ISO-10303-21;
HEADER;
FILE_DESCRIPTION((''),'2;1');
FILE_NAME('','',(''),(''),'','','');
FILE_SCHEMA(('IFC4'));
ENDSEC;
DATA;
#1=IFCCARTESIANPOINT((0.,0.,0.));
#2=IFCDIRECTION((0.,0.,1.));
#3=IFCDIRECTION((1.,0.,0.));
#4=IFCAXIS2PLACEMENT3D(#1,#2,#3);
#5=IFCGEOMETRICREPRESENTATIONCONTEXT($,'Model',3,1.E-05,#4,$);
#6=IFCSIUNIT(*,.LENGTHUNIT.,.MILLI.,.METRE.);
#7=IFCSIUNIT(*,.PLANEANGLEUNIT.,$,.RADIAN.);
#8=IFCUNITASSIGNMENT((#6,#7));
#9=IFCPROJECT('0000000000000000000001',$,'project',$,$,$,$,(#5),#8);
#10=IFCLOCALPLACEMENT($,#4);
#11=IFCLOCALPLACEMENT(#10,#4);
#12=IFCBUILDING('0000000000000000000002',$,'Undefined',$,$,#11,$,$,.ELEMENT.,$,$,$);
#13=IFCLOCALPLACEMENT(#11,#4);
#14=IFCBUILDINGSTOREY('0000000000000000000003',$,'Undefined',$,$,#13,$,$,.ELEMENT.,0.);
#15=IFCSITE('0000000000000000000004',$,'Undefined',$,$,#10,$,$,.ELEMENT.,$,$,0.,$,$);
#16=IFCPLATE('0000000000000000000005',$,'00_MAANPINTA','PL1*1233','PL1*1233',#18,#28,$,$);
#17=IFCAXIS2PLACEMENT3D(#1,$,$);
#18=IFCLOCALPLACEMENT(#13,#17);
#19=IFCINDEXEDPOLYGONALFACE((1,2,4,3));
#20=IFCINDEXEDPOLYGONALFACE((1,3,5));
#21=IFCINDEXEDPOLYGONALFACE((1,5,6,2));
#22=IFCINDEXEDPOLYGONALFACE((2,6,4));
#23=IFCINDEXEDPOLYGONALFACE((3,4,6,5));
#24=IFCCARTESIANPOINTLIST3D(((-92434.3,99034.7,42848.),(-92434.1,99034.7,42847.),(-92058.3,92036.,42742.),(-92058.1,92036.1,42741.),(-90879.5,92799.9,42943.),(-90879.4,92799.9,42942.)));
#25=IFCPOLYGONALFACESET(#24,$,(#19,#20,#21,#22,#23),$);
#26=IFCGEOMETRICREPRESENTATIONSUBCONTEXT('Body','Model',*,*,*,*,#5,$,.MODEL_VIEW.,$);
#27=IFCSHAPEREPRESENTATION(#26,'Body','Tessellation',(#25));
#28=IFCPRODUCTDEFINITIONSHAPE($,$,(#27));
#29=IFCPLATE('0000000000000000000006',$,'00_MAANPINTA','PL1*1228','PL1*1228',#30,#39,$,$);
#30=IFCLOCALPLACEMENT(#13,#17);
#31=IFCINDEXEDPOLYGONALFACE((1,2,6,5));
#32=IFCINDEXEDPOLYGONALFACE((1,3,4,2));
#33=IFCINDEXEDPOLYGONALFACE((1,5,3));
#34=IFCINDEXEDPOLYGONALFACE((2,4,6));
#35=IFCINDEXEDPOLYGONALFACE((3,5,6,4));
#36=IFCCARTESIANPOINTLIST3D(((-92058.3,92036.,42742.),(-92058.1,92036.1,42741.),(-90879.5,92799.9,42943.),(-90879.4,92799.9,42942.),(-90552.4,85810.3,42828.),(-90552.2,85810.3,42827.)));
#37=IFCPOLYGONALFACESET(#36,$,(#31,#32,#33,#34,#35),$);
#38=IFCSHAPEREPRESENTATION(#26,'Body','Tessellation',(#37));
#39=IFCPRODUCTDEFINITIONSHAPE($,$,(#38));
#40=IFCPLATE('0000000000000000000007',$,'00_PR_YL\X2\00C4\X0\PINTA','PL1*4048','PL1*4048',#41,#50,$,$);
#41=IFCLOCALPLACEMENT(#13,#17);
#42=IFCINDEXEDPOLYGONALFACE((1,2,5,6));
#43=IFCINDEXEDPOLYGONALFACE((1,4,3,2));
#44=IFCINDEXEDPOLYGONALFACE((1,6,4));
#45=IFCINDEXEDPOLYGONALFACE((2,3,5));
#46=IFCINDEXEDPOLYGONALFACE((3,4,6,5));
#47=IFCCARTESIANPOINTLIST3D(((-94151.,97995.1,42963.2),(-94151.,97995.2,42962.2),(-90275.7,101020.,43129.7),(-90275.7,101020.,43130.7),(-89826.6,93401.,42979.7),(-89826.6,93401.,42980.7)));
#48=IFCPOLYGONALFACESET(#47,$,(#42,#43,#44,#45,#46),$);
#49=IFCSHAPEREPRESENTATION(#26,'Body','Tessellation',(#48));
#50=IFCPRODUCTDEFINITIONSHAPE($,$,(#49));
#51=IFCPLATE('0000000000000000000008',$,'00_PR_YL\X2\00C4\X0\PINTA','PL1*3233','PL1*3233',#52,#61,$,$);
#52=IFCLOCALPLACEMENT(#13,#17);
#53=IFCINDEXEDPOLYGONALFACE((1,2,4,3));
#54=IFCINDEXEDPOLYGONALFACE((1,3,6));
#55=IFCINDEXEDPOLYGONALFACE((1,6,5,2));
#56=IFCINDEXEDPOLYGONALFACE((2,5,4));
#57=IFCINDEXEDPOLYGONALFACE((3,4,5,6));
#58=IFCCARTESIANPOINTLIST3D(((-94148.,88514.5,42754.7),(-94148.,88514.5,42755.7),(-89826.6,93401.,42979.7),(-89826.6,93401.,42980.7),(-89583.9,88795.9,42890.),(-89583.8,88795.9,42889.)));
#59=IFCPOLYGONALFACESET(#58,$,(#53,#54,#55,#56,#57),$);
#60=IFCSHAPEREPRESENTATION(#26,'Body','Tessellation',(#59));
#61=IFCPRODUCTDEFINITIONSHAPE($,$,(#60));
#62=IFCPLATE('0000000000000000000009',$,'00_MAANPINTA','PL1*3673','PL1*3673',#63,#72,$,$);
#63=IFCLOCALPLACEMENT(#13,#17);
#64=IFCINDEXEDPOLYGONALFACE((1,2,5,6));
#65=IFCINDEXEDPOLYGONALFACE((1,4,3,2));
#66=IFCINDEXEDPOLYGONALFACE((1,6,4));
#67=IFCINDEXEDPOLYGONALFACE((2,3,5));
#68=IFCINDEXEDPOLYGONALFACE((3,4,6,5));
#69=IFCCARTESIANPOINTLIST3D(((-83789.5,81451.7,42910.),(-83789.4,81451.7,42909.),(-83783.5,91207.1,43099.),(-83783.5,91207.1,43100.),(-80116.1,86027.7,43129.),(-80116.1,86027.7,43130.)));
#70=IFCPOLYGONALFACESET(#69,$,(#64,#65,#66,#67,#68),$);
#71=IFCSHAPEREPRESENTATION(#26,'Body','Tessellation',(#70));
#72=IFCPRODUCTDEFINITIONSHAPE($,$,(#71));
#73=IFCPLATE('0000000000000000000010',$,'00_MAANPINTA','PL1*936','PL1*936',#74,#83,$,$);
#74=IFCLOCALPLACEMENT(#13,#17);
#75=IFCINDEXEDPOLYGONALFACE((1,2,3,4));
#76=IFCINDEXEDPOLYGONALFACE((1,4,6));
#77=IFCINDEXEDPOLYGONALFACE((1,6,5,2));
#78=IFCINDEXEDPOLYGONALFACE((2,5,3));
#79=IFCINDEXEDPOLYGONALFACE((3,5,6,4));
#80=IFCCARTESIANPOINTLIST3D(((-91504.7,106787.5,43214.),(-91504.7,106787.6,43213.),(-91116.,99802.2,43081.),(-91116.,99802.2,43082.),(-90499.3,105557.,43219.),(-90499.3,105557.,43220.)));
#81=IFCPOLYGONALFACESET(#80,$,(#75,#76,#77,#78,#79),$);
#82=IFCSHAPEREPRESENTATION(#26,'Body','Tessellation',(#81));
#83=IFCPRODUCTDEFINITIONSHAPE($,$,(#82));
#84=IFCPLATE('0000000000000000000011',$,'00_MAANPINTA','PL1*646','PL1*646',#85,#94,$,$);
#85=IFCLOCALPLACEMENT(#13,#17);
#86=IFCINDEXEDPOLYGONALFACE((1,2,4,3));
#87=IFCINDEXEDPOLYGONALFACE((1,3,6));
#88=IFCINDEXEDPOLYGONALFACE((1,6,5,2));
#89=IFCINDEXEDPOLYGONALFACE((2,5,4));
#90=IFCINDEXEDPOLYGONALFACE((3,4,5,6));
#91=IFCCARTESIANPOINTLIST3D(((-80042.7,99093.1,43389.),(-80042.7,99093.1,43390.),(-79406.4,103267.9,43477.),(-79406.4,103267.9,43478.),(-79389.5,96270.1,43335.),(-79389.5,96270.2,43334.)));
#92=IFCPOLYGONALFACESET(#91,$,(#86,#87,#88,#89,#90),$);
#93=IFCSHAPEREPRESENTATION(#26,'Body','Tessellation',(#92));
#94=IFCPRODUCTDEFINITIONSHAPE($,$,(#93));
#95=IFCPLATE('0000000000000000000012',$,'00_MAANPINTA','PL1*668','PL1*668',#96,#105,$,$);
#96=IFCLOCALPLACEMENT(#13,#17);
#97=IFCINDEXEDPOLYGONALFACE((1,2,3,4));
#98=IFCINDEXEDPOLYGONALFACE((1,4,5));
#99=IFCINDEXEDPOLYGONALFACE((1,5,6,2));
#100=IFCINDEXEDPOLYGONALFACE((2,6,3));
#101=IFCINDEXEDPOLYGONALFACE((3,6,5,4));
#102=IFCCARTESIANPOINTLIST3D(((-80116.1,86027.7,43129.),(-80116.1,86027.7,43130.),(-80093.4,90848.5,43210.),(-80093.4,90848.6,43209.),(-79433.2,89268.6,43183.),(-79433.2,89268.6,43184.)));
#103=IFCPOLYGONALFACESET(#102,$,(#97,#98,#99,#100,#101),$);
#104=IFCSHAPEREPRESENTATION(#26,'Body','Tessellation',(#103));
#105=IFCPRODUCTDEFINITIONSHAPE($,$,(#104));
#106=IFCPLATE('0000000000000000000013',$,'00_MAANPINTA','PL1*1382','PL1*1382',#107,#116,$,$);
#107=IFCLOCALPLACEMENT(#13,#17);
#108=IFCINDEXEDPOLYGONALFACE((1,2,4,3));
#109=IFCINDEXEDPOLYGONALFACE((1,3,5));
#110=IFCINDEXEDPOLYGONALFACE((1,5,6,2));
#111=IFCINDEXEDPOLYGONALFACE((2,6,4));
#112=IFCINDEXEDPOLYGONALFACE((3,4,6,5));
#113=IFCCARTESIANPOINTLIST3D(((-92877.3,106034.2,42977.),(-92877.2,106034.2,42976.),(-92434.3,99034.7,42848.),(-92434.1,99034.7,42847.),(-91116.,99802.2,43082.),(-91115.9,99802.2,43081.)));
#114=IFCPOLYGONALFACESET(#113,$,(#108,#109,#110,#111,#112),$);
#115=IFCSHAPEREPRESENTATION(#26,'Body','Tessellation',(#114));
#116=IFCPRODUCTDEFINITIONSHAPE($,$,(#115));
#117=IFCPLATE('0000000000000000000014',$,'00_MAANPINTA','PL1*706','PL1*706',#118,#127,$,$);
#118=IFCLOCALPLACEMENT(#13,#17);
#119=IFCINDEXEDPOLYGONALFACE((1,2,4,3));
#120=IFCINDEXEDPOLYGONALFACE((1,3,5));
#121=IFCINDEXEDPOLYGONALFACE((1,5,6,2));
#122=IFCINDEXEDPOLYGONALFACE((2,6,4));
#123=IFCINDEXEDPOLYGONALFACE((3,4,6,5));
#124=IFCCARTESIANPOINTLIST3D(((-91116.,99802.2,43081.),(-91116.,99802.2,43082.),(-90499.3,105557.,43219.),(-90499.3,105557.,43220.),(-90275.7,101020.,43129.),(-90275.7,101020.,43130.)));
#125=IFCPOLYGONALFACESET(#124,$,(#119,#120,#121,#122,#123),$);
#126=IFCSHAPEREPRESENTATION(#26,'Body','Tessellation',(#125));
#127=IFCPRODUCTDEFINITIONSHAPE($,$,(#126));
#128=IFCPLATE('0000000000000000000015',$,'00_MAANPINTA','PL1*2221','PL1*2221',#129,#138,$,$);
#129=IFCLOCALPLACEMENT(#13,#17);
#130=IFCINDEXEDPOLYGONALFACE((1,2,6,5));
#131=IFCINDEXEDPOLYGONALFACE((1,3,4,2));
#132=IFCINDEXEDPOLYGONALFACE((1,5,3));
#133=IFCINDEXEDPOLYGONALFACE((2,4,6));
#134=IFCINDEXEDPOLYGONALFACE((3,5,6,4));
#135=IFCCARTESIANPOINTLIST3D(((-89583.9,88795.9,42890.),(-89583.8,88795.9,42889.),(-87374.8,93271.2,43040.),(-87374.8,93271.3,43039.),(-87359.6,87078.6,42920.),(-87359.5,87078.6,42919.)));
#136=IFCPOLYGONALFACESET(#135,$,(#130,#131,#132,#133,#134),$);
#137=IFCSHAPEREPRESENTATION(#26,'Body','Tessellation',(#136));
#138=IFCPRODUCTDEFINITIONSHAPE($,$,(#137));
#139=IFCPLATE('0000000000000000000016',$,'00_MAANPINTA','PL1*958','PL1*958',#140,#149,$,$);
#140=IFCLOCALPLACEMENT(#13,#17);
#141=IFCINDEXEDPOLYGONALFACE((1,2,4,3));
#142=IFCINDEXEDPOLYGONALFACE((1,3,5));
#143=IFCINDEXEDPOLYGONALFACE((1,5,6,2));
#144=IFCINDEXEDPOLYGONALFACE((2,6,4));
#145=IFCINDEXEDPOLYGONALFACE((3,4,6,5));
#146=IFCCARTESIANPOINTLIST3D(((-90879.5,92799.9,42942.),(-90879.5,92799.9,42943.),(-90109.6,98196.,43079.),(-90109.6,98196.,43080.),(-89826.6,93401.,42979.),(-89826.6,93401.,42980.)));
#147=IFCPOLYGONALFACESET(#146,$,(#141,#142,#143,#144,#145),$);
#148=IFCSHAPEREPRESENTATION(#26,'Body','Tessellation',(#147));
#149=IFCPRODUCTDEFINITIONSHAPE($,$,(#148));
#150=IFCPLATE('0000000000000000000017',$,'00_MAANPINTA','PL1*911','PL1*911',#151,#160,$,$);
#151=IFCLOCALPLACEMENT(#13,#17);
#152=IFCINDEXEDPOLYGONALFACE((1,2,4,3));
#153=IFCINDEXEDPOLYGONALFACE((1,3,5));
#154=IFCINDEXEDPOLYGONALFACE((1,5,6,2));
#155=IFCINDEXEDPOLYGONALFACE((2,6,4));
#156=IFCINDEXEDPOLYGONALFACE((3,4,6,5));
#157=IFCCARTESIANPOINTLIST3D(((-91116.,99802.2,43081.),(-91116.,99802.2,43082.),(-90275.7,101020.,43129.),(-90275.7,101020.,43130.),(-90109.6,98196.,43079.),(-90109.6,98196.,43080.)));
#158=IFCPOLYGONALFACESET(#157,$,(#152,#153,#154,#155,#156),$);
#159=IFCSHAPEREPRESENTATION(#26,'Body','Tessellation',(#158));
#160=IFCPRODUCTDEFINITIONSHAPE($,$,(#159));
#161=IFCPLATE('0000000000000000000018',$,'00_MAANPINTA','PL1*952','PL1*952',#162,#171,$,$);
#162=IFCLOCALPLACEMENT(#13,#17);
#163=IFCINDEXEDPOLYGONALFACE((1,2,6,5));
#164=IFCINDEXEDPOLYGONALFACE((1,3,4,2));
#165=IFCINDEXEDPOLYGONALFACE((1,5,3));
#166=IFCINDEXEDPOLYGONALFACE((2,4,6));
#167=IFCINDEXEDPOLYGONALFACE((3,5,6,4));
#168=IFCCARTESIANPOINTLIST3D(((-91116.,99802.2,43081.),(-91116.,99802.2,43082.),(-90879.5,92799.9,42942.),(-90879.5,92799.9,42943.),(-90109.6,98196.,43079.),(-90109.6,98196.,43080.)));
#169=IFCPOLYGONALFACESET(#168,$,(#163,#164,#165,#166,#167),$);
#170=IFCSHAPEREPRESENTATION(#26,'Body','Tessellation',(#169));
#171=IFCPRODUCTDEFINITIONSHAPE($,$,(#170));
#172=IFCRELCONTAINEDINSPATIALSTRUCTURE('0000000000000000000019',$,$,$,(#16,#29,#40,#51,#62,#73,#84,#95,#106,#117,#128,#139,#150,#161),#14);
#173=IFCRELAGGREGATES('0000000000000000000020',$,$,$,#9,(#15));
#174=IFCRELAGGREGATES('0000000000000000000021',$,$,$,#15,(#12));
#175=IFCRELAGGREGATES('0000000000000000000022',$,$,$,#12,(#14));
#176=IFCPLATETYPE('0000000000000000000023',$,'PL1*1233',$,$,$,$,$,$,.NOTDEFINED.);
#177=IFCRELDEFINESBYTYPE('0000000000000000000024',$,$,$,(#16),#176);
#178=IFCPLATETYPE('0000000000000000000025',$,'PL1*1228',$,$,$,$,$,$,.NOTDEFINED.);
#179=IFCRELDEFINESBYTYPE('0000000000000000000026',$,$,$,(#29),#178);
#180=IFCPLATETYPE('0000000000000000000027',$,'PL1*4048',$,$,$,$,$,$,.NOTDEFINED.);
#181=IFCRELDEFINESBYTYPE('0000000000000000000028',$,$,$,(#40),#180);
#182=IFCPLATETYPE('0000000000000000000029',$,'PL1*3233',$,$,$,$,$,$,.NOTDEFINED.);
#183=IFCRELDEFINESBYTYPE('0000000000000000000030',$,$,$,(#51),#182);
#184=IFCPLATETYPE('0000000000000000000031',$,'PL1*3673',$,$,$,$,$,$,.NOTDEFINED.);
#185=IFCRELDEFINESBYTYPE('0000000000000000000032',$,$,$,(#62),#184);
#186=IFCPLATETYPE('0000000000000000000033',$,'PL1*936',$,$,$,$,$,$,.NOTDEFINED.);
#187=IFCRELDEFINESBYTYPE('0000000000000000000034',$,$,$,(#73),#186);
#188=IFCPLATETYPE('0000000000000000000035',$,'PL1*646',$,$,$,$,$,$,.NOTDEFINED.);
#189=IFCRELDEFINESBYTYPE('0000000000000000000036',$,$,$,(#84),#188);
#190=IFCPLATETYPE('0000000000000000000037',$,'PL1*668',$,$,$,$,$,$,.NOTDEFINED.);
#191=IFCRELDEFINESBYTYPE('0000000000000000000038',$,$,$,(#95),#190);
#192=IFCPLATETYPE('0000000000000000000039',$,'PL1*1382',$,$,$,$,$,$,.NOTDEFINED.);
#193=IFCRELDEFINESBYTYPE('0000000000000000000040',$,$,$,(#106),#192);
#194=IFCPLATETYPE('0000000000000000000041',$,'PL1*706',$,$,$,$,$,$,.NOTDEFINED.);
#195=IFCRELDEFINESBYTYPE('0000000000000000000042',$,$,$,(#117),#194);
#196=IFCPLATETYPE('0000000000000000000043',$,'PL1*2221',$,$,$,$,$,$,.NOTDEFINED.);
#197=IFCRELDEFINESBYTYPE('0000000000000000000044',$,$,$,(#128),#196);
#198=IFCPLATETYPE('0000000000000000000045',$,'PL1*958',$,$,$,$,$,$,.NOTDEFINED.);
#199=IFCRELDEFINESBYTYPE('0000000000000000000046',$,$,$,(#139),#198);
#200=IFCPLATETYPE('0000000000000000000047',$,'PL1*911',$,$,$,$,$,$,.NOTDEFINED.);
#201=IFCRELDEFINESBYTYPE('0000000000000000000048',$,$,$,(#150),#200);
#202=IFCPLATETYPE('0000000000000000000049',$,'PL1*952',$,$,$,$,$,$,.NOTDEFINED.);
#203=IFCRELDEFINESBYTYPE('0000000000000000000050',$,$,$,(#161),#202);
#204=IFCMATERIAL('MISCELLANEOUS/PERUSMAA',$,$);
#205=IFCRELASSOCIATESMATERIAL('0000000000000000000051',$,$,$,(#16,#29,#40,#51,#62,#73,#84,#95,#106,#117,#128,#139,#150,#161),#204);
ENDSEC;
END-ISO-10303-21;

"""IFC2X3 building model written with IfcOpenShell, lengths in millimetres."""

from ifc_helpers import new_model, si_unit, frame, origin_with_axes, place, context, subcontext, project, spatial, polyline, outline, extrude, material, type_object, element, save


model = new_model("IFC2X3")

# Units and contexts
model_context = context("Model", 3, precision=1e-05, world=origin_with_axes())
body_context = subcontext(model_context, "Body", "Model", "MODEL_VIEW")
ifc_project = project(units=[si_unit("LENGTHUNIT", "METRE", prefix="MILLI"), si_unit("PLANEANGLEUNIT", "RADIAN")], contexts=[model_context])

# Site, building, storey
site_placement = place(None, origin_with_axes())
site = spatial("IfcSite", under=ifc_project, at=site_placement, Name="Undefined", CompositionType="ELEMENT", RefElevation=0.0)
building_placement = place(site_placement, origin_with_axes())
building = spatial("IfcBuilding", under=site, at=building_placement, Name="Undefined", CompositionType="ELEMENT")
storey_placement = place(building_placement, origin_with_axes())
storey = spatial("IfcBuildingStorey", under=building, at=storey_placement, Name="Undefined", CompositionType="ELEMENT", Elevation=0.0)

# Plates
ifc_material = material(Name="MISCELLANEOUS/PERUSMAA")
plate_type_1 = type_object("IfcPlateType", Name="PL1*1233", PredefinedType="NOTDEFINED")
plate_1_placement = place(storey_placement, frame((-90879.4, 92799.9, 42942.5), z_axis=(0.153412, 0.023203, -0.98789), x_axis=(-0.830745, -0.538328, -0.141653)))
element("IfcPlate", 1, at=plate_1_placement, inside=storey, type_object=plate_type_1, material=ifc_material, Name="00_MAANPINTA", Description="PL1*1233", ObjectType="PL1*1233", context=body_context, shape_type="SweptSolid", body=[
    extrude(outline(polyline([(0.0, 0.0), (1419.0, 0.0), (-2051.3, 6090.2), (0.0, 0.0)])), frame((0.0, 0.0, -0.5), z_axis=(0.0, 0.0, 1.0), x_axis=(1.0, 0.0, 0.0)), (0.0, 0.0, 1.0), 1.0),
])
plate_type_2 = type_object("IfcPlateType", Name="PL1*1228", PredefinedType="NOTDEFINED")
plate_2_placement = place(storey_placement, frame((-90879.4, 92799.9, 42942.5), z_axis=(0.15327, 0.023427, -0.987907), x_axis=(0.046745, -0.998772, -0.016433)))
element("IfcPlate", 2, at=plate_2_placement, inside=storey, type_object=plate_type_2, material=ifc_material, Name="00_MAANPINTA", Description="PL1*1228", ObjectType="PL1*1228", context=body_context, shape_type="SweptSolid", body=[
    extrude(outline(polyline([(0.0, 0.0), (6998.2, 0.0), (711.1, 1227.9), (0.0, 0.0)])), frame((0.0, 0.0, -0.5), z_axis=(0.0, 0.0, 1.0), x_axis=(1.0, 0.0, 0.0)), (0.0, 0.0, 1.0), 1.0),
])
plate_type_3 = type_object("IfcPlateType", Name="PL1*4048", PredefinedType="NOTDEFINED")
plate_3_placement = place(storey_placement, frame((-90275.7, 101020.0, 43130.2), z_axis=(0.02661, 0.02125, -0.99942), x_axis=(0.058825, -0.998075, -0.019655)))
element("IfcPlate", 3, at=plate_3_placement, inside=storey, type_object=plate_type_3, material=ifc_material, Name="00_PR_YLÄPINTA", Description="PL1*4048", ObjectType="PL1*4048", context=body_context, shape_type="SweptSolid", body=[
    extrude(outline(polyline([(0.0, 0.0), (7633.7, 0.0), (2794.4, 4048.2), (0.0, 0.0)])), frame((0.0, 0.0, -0.5), z_axis=(0.0, 0.0, 1.0), x_axis=(1.0, 0.0, 0.0)), (0.0, 0.0, 1.0), 1.0),
])
plate_type_4 = type_object("IfcPlateType", Name="PL1*3233", PredefinedType="NOTDEFINED")
plate_4_placement = place(storey_placement, frame((-89826.6, 93401.0, 42980.2), z_axis=(0.02811, 0.021156, -0.999381), x_axis=(0.052634, -0.99842, -0.019655)))
element("IfcPlate", 4, at=plate_4_placement, inside=storey, type_object=plate_type_4, material=ifc_material, Name="00_PR_YLÄPINTA", Description="PL1*3233", ObjectType="PL1*3233", context=body_context, shape_type="SweptSolid", body=[
    extrude(outline(polyline([(0.0, 0.0), (4612.4, 0.0), (4655.7, 4574.6), (0.0, 0.0)])), frame((0.0, 0.0, -0.5), z_axis=(0.0, 0.0, 1.0), x_axis=(1.0, 0.0, 0.0)), (0.0, 0.0, 1.0), 1.0),
])
plate_type_5 = type_object("IfcPlateType", Name="PL1*3673", PredefinedType="NOTDEFINED")
plate_5_placement = place(storey_placement, frame((-83783.5, 91207.1, 43099.5), z_axis=(0.035626, 0.019438, -0.999176), x_axis=(0.577874, -0.816113, 0.004727)))
element("IfcPlate", 5, at=plate_5_placement, inside=storey, type_object=plate_type_5, material=ifc_material, Name="00_MAANPINTA", Description="PL1*3673", ObjectType="PL1*3673", context=body_context, shape_type="SweptSolid", body=[
    extrude(outline(polyline([(0.0, 0.0), (6346.4, 0.0), (7957.2, 5646.9), (0.0, 0.0)])), frame((0.0, 0.0, -0.5), z_axis=(0.0, 0.0, 1.0), x_axis=(1.0, 0.0, 0.0)), (0.0, 0.0, 1.0), 1.0),
])
plate_type_6 = type_object("IfcPlateType", Name="PL1*936", PredefinedType="NOTDEFINED")
plate_6_placement = place(storey_placement, frame((-91116.0, 99802.2, 43081.5), z_axis=(0.0312, 0.020619, -0.9993), x_axis=(-0.055545, 0.998278, 0.018864)))
element("IfcPlate", 6, at=plate_6_placement, inside=storey, type_object=plate_type_6, material=ifc_material, Name="00_MAANPINTA", Description="PL1*936", ObjectType="PL1*936", context=body_context, shape_type="SweptSolid", body=[
    extrude(outline(polyline([(0.0, 0.0), (6997.4, 0.0), (5713.2, 936.0), (0.0, 0.0)])), frame((0.0, 0.0, -0.5), z_axis=(0.0, 0.0, 1.0), x_axis=(1.0, 0.0, 0.0)), (0.0, 0.0, 1.0), 1.0),
])
plate_type_7 = type_object("IfcPlateType", Name="PL1*646", PredefinedType="NOTDEFINED")
plate_7_placement = place(storey_placement, frame((-80042.7, 99093.1, 43389.5), z_axis=(0.004157, 0.020441, -0.999782), x_axis=(0.15064, 0.988369, 0.020834)))
element("IfcPlate", 7, at=plate_7_placement, inside=storey, type_object=plate_type_7, material=ifc_material, Name="00_MAANPINTA", Description="PL1*646", ObjectType="PL1*646", context=body_context, shape_type="SweptSolid", body=[
    extrude(outline(polyline([(0.0, 0.0), (4223.9, 0.0), (-2692.8, 1071.1), (0.0, 0.0)])), frame((0.0, 0.0, -0.5), z_axis=(0.0, 0.0, 1.0), x_axis=(1.0, 0.0, 0.0)), (0.0, 0.0, 1.0), 1.0),
])
plate_type_8 = type_object("IfcPlateType", Name="PL1*668", PredefinedType="NOTDEFINED")
plate_8_placement = place(storey_placement, frame((-80093.4, 90848.6, 43209.5), z_axis=(0.000328, 0.016591, -0.999862), x_axis=(0.38552, -0.922574, -0.015182)))
element("IfcPlate", 8, at=plate_8_placement, inside=storey, type_object=plate_type_8, material=ifc_material, Name="00_MAANPINTA", Description="PL1*668", ObjectType="PL1*668", context=body_context, shape_type="SweptSolid", body=[
    extrude(outline(polyline([(0.0, 0.0), (1712.6, 0.0), (4440.0, 1879.7), (0.0, 0.0)])), frame((0.0, 0.0, -0.5), z_axis=(0.0, 0.0, 1.0), x_axis=(1.0, 0.0, 0.0)), (0.0, 0.0, 1.0), 1.0),
])
plate_type_9 = type_object("IfcPlateType", Name="PL1*1382", PredefinedType="NOTDEFINED")
plate_9_placement = place(storey_placement, frame((-91116.0, 99802.2, 43081.5), z_axis=(0.158749, 0.028237, -0.986915), x_axis=(-0.854187, -0.497367, -0.15163)))
element("IfcPlate", 9, at=plate_9_placement, inside=storey, type_object=plate_type_9, material=ifc_material, Name="00_MAANPINTA", Description="PL1*1382", ObjectType="PL1*1382", context=body_context, shape_type="SweptSolid", body=[
    extrude(outline(polyline([(0.0, 0.0), (1543.2, 0.0), (-1579.2, 6281.5), (0.0, 0.0)])), frame((0.0, 0.0, -0.5), z_axis=(0.0, 0.0, 1.0), x_axis=(1.0, 0.0, 0.0)), (0.0, 0.0, 1.0), 1.0),
])
plate_type_10 = type_object("IfcPlateType", Name="PL1*706", PredefinedType="NOTDEFINED")
plate_10_placement = place(storey_placement, frame((-91116.0, 99802.2, 43081.5), z_axis=(0.026466, 0.02113, -0.999426), x_axis=(0.106531, 0.994024, 0.023837)))
element("IfcPlate", 10, at=plate_10_placement, inside=storey, type_object=plate_type_10, material=ifc_material, Name="00_MAANPINTA", Description="PL1*706", ObjectType="PL1*706", context=body_context, shape_type="SweptSolid", body=[
    extrude(outline(polyline([(0.0, 0.0), (5789.4, 0.0), (1301.2, 706.0), (0.0, 0.0)])), frame((0.0, 0.0, -0.5), z_axis=(0.0, 0.0, 1.0), x_axis=(1.0, 0.0, 0.0)), (0.0, 0.0, 1.0), 1.0),
])
plate_type_11 = type_object("IfcPlateType", Name="PL1*2221", PredefinedType="NOTDEFINED")
plate_11_placement = place(storey_placement, frame((-87374.8, 93271.3, 43039.5), z_axis=(0.028485, 0.019436, -0.999405), x_axis=(0.002463, -0.999809, -0.019374)))
element("IfcPlate", 11, at=plate_11_placement, inside=storey, type_object=plate_type_11, material=ifc_material, Name="00_MAANPINTA", Description="PL1*2221", ObjectType="PL1*2221", context=body_context, shape_type="SweptSolid", body=[
    extrude(outline(polyline([(0.0, 0.0), (6193.8, 0.0), (4472.0, 2221.0), (0.0, 0.0)])), frame((0.0, 0.0, -0.5), z_axis=(0.0, 0.0, 1.0), x_axis=(1.0, 0.0, 0.0)), (0.0, 0.0, 1.0), 1.0),
])
plate_type_12 = type_object("IfcPlateType", Name="PL1*958", PredefinedType="NOTDEFINED")
plate_12_placement = place(storey_placement, frame((-90879.5, 92799.9, 42942.5), z_axis=(0.022468, 0.022171, -0.999502), x_axis=(0.141198, 0.989663, 0.025126)))
element("IfcPlate", 12, at=plate_12_placement, inside=storey, type_object=plate_type_12, material=ifc_material, Name="00_MAANPINTA", Description="PL1*958", ObjectType="PL1*958", context=body_context, shape_type="SweptSolid", body=[
    extrude(outline(polyline([(0.0, 0.0), (5452.4, 0.0), (744.4, 957.6), (0.0, 0.0)])), frame((0.0, 0.0, -0.5), z_axis=(0.0, 0.0, 1.0), x_axis=(1.0, 0.0, 0.0)), (0.0, 0.0, 1.0), 1.0),
])
plate_type_13 = type_object("IfcPlateType", Name="PL1*911", PredefinedType="NOTDEFINED")
plate_13_placement = place(storey_placement, frame((-90109.6, 98196.0, 43079.5), z_axis=(0.028973, 0.019398, -0.999392), x_axis=(-0.530953, 0.847401, 0.001055)))
element("IfcPlate", 13, at=plate_13_placement, inside=storey, type_object=plate_type_13, material=ifc_material, Name="00_MAANPINTA", Description="PL1*911", ObjectType="PL1*911", context=body_context, shape_type="SweptSolid", body=[
    extrude(outline(polyline([(0.0, 0.0), (1895.5, 0.0), (2481.3, 1359.5), (0.0, 0.0)])), frame((0.0, 0.0, -0.5), z_axis=(0.0, 0.0, 1.0), x_axis=(1.0, 0.0, 0.0)), (0.0, 0.0, 1.0), 1.0),
])
plate_type_14 = type_object("IfcPlateType", Name="PL1*952", PredefinedType="NOTDEFINED")
plate_14_placement = place(storey_placement, frame((-90879.5, 92799.9, 42942.5), z_axis=(0.031364, 0.020896, -0.99929), x_axis=(-0.033754, 0.999233, 0.019835)))
element("IfcPlate", 14, at=plate_14_placement, inside=storey, type_object=plate_type_14, material=ifc_material, Name="00_MAANPINTA", Description="PL1*952", ObjectType="PL1*952", context=body_context, shape_type="SweptSolid", body=[
    extrude(outline(polyline([(0.0, 0.0), (7007.7, 0.0), (5368.7, 952.1), (0.0, 0.0)])), frame((0.0, 0.0, -0.5), z_axis=(0.0, 0.0, 1.0), x_axis=(1.0, 0.0, 0.0)), (0.0, 0.0, 1.0), 1.0),
])

save(model, "model.ifc")
